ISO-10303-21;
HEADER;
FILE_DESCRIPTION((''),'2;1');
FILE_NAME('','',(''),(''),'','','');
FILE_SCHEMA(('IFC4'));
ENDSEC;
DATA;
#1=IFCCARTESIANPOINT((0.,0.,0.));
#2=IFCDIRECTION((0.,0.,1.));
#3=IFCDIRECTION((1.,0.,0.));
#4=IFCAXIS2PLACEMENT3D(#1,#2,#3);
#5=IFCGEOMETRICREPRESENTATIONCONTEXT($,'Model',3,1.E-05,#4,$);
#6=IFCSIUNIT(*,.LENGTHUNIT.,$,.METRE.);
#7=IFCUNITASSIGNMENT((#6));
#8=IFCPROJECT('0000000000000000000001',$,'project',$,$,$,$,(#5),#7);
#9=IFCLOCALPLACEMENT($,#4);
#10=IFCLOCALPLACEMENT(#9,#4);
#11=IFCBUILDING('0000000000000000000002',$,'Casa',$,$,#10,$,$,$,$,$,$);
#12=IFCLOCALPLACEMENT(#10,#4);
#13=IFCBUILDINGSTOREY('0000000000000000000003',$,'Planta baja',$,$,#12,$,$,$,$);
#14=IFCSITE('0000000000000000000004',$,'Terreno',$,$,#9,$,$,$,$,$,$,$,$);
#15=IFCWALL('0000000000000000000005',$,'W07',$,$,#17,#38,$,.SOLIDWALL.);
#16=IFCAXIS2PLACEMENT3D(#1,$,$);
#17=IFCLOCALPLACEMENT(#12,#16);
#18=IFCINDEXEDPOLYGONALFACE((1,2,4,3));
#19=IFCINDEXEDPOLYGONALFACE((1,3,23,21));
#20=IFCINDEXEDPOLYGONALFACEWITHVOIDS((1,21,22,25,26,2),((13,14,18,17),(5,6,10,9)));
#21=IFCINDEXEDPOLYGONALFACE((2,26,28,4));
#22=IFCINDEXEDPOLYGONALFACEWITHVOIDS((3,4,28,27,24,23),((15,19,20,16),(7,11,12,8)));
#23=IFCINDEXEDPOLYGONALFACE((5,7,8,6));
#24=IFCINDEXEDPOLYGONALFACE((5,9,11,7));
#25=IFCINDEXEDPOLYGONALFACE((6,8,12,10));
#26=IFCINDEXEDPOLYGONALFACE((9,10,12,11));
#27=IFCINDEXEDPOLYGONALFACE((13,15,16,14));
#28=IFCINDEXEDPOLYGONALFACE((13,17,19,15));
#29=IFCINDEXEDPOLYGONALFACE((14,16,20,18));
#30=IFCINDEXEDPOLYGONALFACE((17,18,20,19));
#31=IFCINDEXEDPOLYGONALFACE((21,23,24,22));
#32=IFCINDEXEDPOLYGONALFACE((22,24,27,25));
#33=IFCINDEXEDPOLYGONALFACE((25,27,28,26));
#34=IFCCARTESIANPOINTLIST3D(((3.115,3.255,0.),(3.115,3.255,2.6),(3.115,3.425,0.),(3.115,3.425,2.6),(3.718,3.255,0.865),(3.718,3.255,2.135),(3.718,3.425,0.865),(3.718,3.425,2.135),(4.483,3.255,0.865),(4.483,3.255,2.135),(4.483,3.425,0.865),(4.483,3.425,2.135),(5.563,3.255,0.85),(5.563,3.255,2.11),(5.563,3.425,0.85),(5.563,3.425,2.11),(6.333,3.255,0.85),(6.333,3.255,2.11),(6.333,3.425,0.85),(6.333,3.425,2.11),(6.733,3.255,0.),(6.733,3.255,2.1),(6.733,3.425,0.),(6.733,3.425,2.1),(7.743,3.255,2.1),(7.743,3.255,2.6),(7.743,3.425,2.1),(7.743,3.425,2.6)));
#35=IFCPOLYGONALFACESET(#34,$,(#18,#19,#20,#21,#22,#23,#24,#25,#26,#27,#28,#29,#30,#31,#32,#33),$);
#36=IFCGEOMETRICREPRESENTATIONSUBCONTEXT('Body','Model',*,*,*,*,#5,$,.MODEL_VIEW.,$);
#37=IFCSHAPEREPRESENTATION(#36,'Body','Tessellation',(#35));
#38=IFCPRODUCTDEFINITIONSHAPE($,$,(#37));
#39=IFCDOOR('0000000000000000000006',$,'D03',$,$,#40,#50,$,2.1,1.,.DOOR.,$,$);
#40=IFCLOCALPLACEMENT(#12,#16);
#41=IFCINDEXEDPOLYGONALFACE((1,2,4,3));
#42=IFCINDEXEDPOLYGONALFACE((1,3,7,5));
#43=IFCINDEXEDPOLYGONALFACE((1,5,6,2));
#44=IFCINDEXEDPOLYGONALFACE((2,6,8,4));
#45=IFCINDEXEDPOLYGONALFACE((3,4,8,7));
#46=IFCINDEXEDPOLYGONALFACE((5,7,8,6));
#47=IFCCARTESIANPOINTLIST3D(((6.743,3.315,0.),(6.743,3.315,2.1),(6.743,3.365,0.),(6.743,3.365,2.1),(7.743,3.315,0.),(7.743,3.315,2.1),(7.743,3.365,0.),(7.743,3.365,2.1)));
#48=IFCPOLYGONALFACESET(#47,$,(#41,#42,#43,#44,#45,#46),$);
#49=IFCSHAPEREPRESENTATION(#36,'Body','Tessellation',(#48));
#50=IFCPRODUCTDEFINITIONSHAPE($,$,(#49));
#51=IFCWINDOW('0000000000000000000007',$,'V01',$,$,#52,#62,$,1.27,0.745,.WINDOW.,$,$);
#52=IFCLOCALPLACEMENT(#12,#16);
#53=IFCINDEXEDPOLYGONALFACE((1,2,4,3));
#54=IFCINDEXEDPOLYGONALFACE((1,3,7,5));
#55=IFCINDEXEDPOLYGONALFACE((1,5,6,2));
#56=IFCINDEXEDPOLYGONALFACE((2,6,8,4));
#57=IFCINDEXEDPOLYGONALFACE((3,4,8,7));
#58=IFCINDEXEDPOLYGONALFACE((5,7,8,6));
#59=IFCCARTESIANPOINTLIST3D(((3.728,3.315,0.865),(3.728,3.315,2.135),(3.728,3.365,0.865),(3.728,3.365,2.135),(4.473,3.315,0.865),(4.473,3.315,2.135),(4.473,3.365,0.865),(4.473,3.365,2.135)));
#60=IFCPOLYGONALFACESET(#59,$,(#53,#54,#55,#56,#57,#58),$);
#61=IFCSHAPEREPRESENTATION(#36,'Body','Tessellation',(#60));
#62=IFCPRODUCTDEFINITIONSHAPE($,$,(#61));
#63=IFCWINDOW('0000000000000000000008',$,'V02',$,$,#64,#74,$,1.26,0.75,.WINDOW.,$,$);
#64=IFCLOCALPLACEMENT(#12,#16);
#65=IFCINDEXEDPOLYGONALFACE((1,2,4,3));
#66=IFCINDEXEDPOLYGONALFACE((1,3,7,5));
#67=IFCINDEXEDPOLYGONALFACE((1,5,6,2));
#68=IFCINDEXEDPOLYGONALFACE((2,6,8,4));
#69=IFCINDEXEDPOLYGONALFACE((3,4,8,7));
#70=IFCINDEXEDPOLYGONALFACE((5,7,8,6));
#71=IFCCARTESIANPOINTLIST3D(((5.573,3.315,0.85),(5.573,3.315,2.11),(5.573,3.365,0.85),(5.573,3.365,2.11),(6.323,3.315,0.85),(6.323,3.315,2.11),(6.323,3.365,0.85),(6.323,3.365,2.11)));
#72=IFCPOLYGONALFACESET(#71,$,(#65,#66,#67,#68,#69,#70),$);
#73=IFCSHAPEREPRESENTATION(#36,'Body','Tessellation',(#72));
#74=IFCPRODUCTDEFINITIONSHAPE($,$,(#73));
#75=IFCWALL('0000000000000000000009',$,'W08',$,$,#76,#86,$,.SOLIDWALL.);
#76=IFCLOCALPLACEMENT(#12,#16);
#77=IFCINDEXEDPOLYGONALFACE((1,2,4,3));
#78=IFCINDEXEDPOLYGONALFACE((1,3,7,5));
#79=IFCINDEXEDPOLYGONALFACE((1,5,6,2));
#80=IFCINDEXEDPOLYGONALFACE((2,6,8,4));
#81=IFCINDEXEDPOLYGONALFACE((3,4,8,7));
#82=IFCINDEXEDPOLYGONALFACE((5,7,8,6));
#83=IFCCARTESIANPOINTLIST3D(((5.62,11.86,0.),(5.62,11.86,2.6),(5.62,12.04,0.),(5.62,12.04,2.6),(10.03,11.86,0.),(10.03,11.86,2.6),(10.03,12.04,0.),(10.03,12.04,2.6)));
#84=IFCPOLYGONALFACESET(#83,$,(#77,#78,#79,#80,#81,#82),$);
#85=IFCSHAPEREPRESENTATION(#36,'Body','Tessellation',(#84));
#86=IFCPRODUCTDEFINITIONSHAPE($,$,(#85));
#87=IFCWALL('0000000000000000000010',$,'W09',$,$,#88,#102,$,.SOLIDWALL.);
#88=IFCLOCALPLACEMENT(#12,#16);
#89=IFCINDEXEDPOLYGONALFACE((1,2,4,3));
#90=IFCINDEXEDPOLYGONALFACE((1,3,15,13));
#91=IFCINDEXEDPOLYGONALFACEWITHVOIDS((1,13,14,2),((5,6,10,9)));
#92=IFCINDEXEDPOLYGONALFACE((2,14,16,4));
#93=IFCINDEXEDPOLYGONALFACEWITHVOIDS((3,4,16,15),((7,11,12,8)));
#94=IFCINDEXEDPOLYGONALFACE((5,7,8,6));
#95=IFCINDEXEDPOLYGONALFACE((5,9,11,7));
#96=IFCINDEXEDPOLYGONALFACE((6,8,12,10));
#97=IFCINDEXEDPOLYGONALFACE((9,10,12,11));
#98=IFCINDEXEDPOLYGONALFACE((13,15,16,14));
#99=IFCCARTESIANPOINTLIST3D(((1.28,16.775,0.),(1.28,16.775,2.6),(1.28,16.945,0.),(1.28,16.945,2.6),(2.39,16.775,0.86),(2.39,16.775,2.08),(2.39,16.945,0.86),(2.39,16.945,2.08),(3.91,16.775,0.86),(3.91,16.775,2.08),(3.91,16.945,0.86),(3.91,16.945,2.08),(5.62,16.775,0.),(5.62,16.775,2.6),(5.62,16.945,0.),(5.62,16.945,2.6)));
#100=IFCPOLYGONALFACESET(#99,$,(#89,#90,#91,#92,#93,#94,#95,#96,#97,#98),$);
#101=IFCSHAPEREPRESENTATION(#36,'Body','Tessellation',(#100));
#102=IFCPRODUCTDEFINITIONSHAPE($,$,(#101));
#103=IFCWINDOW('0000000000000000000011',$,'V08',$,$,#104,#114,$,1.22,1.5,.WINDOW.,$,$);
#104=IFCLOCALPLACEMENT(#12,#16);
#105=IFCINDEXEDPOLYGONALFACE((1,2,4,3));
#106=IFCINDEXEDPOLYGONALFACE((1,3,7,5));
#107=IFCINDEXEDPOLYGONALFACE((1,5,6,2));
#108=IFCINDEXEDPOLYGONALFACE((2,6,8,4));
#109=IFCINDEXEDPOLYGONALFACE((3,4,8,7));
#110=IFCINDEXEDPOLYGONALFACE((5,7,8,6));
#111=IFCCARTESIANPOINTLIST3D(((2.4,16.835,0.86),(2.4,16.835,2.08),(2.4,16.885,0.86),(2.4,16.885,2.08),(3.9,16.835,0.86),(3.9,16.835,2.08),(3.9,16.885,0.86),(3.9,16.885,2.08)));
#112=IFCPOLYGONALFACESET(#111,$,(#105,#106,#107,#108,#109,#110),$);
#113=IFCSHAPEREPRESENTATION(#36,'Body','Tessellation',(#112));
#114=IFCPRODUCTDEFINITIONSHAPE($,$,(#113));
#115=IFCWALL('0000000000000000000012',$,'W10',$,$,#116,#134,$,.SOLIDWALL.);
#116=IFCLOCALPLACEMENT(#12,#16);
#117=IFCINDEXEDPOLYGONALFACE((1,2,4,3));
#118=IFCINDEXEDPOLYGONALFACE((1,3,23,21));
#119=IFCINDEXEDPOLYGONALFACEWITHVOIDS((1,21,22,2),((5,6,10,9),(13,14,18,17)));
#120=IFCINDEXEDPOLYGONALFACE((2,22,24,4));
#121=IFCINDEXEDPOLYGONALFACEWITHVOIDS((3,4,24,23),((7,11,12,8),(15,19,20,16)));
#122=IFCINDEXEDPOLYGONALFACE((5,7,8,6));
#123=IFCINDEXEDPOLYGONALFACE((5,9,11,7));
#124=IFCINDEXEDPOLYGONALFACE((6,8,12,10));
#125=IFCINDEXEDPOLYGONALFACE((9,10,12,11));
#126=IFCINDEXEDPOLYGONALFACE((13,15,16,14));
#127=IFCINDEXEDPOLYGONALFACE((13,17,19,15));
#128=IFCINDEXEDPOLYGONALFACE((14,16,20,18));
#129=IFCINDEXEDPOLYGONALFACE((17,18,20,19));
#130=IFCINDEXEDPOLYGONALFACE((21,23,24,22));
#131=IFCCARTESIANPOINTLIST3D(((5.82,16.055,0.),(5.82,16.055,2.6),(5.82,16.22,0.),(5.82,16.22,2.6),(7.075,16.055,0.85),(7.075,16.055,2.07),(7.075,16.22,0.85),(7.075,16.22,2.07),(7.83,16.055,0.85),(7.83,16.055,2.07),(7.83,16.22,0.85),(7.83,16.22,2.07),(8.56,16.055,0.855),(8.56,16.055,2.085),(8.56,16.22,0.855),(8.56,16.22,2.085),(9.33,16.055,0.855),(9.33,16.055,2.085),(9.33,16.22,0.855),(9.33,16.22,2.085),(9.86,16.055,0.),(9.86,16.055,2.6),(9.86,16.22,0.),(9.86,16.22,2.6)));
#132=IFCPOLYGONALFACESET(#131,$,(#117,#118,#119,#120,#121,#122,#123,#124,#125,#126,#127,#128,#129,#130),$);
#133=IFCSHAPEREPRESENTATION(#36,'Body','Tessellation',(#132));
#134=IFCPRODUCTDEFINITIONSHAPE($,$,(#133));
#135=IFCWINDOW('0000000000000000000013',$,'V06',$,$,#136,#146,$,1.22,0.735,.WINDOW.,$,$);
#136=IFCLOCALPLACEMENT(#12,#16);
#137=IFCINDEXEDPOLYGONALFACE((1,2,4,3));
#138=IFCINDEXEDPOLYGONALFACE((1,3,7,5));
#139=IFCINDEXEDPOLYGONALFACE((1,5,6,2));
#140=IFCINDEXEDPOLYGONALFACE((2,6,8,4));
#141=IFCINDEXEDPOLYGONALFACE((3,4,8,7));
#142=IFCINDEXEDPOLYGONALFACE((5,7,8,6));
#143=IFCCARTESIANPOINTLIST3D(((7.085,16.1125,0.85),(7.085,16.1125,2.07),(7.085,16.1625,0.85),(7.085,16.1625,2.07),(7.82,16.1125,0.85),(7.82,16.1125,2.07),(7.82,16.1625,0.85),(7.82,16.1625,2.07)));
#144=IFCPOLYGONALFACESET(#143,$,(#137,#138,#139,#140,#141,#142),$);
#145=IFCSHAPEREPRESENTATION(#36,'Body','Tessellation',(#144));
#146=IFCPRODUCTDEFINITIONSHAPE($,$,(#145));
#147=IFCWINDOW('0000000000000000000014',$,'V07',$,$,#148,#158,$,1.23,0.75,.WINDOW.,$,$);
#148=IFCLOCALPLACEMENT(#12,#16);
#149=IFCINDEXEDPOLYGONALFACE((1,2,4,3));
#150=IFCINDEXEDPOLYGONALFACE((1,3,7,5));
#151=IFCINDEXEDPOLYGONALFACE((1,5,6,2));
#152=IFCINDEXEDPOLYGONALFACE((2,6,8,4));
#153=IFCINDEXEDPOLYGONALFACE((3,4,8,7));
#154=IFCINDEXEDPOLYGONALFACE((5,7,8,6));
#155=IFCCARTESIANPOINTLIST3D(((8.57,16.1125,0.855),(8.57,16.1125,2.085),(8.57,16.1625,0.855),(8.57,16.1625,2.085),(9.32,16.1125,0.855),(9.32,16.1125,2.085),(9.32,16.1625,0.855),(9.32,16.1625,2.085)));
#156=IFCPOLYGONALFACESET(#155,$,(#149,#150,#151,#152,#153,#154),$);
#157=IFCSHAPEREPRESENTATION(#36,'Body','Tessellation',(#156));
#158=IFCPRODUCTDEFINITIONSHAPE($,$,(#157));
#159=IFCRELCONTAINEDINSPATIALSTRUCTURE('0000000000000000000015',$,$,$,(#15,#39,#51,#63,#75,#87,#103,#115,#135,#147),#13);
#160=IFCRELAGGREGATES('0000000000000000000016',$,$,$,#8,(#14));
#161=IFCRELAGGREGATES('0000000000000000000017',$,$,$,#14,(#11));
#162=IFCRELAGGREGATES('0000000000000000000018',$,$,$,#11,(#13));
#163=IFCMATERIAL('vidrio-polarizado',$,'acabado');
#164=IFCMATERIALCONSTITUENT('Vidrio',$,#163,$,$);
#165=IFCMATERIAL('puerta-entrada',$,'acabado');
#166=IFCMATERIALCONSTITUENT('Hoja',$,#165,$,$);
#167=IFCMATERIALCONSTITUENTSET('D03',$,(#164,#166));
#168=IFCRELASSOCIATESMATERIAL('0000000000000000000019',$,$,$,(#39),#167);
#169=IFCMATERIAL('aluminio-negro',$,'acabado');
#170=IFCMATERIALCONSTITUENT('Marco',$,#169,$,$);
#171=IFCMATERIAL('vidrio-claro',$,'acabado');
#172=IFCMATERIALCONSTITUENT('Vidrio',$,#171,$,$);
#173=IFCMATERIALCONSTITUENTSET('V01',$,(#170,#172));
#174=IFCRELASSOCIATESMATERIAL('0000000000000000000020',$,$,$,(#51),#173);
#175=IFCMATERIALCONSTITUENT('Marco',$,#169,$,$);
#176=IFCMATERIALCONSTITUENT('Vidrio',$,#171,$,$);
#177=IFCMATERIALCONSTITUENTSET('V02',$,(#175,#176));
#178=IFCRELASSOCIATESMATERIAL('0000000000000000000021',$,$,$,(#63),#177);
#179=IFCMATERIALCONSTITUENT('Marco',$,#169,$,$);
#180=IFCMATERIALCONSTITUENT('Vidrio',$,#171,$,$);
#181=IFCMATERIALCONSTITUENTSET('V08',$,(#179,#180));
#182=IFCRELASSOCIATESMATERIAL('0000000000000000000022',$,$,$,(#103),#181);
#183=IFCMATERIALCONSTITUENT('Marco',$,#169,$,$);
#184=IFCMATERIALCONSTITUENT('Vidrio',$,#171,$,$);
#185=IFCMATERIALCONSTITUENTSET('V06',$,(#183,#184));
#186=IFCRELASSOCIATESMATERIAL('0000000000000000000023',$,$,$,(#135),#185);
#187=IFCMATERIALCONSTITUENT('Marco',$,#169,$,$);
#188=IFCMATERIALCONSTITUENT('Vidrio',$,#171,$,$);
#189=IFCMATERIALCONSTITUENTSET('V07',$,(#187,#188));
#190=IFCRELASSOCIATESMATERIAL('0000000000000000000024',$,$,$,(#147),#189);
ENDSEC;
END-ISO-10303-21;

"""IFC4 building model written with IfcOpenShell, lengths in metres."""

from ifc_helpers import new_model, si_unit, frame, origin_with_axes, place, context, subcontext, project, spatial, line, indexed_curve, outline, extrude, material, constituent, constituent_set, element, fill, save


model = new_model("IFC4")

# Units and contexts
model_context = context("Model", 3, precision=1e-05, world=origin_with_axes())
body_context = subcontext(model_context, "Body", "Model", "MODEL_VIEW")
ifc_project = project(units=[si_unit("LENGTHUNIT", "METRE")], contexts=[model_context])

# Site, building, storey
site_placement = place(None, origin_with_axes())
site = spatial("IfcSite", under=ifc_project, at=site_placement, Name="Terreno")
building_placement = place(site_placement, origin_with_axes())
building = spatial("IfcBuilding", under=site, at=building_placement, Name="Casa")
storey_placement = place(building_placement, origin_with_axes())
storey = spatial("IfcBuildingStorey", under=building, at=storey_placement, Name="Planta baja")

# Wall, openings, door, windows
wall_1_placement = place(storey_placement, origin_with_axes())
wall_1 = element("IfcWall", 1, at=wall_1_placement, inside=storey, Name="W07", PredefinedType="SOLIDWALL", context=body_context, shape_type="SweptSolid", body=[
    extrude(outline(indexed_curve([(3.115, 3.425), (7.743, 3.425), (7.743, 3.255), (3.115, 3.255)], segments=[line(1, 2, 3, 4, 1)])), origin_with_axes(), (0.0, 0.0, 1.0), 2.6),
])
opening_1_placement = place(wall_1_placement, origin_with_axes())
opening_1 = element("IfcOpeningElement", 2, at=opening_1_placement, cuts=wall_1, PredefinedType="OPENING", context=body_context, shape_type="SweptSolid", body=[
    extrude(outline(indexed_curve([(6.733, 3.245), (7.753, 3.245), (7.753, 3.435), (6.733, 3.435)], segments=[line(1, 2, 3, 4, 1)])), origin_with_axes(), (0.0, 0.0, 1.0), 2.1),
])
opening_2_placement = place(wall_1_placement, origin_with_axes())
opening_2 = element("IfcOpeningElement", 3, at=opening_2_placement, cuts=wall_1, PredefinedType="OPENING", context=body_context, shape_type="SweptSolid", body=[
    extrude(outline(indexed_curve([(3.718, 3.245), (4.483, 3.245), (4.483, 3.435), (3.718, 3.435)], segments=[line(1, 2, 3, 4, 1)])), frame((0.0, 0.0, 0.865), z_axis=(0.0, 0.0, 1.0), x_axis=(1.0, 0.0, 0.0)), (0.0, 0.0, 1.0), 1.27),
])
opening_3_placement = place(wall_1_placement, origin_with_axes())
opening_3 = element("IfcOpeningElement", 4, at=opening_3_placement, cuts=wall_1, PredefinedType="OPENING", context=body_context, shape_type="SweptSolid", body=[
    extrude(outline(indexed_curve([(5.563, 3.245), (6.333, 3.245), (6.333, 3.435), (5.563, 3.435)], segments=[line(1, 2, 3, 4, 1)])), frame((0.0, 0.0, 0.85), z_axis=(0.0, 0.0, 1.0), x_axis=(1.0, 0.0, 0.0)), (0.0, 0.0, 1.0), 1.26),
])
ifc_material_1 = material(Name="vidrio-polarizado", Category="acabado")
ifc_constituent_1 = constituent(ifc_material_1, Name="Vidrio")
ifc_material_2 = material(Name="puerta-entrada", Category="acabado")
ifc_constituent_2 = constituent(ifc_material_2, Name="Hoja")
ifc_constituent_set_1 = constituent_set(constituents=[ifc_constituent_1, ifc_constituent_2], Name="D03")
door_1_placement = place(opening_1_placement, origin_with_axes())
door_1 = element("IfcDoor", 5, at=door_1_placement, inside=storey, material=ifc_constituent_set_1, Name="D03", OverallHeight=2.1, OverallWidth=1.0, PredefinedType="DOOR", context=body_context, shape_type="SweptSolid", body=[
    extrude(outline(indexed_curve([(6.743, 3.315), (7.743, 3.315), (7.743, 3.365), (6.743, 3.365)], segments=[line(1, 2, 3, 4, 1)])), origin_with_axes(), (0.0, 0.0, 1.0), 2.1),
])
fill(opening_1, door_1)
ifc_material_3 = material(Name="aluminio-negro", Category="acabado")
ifc_constituent_3 = constituent(ifc_material_3, Name="Marco")
ifc_material_4 = material(Name="vidrio-claro", Category="acabado")
ifc_constituent_4 = constituent(ifc_material_4, Name="Vidrio")
ifc_constituent_set_2 = constituent_set(constituents=[ifc_constituent_3, ifc_constituent_4], Name="V01")
window_1_placement = place(opening_2_placement, origin_with_axes())
window_1 = element("IfcWindow", 6, at=window_1_placement, inside=storey, material=ifc_constituent_set_2, Name="V01", OverallHeight=1.27, OverallWidth=0.745, PredefinedType="WINDOW", context=body_context, shape_type="SweptSolid", body=[
    extrude(outline(indexed_curve([(3.728, 3.315), (4.473, 3.315), (4.473, 3.365), (3.728, 3.365)], segments=[line(1, 2, 3, 4, 1)])), frame((0.0, 0.0, 0.865), z_axis=(0.0, 0.0, 1.0), x_axis=(1.0, 0.0, 0.0)), (0.0, 0.0, 1.0), 1.27),
])
fill(opening_2, window_1)
ifc_constituent_5 = constituent(ifc_material_3, Name="Marco")
ifc_constituent_6 = constituent(ifc_material_4, Name="Vidrio")
ifc_constituent_set_3 = constituent_set(constituents=[ifc_constituent_5, ifc_constituent_6], Name="V02")
window_2_placement = place(opening_3_placement, origin_with_axes())
window_2 = element("IfcWindow", 7, at=window_2_placement, inside=storey, material=ifc_constituent_set_3, Name="V02", OverallHeight=1.26, OverallWidth=0.75, PredefinedType="WINDOW", context=body_context, shape_type="SweptSolid", body=[
    extrude(outline(indexed_curve([(5.573, 3.315), (6.323, 3.315), (6.323, 3.365), (5.573, 3.365)], segments=[line(1, 2, 3, 4, 1)])), frame((0.0, 0.0, 0.85), z_axis=(0.0, 0.0, 1.0), x_axis=(1.0, 0.0, 0.0)), (0.0, 0.0, 1.0), 1.26),
])
fill(opening_3, window_2)

# Wall
wall_2_placement = place(storey_placement, origin_with_axes())
element("IfcWall", 8, at=wall_2_placement, inside=storey, Name="W08", PredefinedType="SOLIDWALL", context=body_context, shape_type="SweptSolid", body=[
    extrude(outline(indexed_curve([(5.62, 11.86), (5.62, 12.04), (10.03, 12.04), (10.03, 11.86)], segments=[line(1, 2, 3, 4, 1)])), origin_with_axes(), (0.0, 0.0, 1.0), 2.6),
])

# Wall, opening, window
wall_3_placement = place(storey_placement, origin_with_axes())
wall_3 = element("IfcWall", 9, at=wall_3_placement, inside=storey, Name="W09", PredefinedType="SOLIDWALL", context=body_context, shape_type="SweptSolid", body=[
    extrude(outline(indexed_curve([(1.28, 16.775), (1.28, 16.945), (5.62, 16.945), (5.62, 16.775)], segments=[line(1, 2, 3, 4, 1)])), origin_with_axes(), (0.0, 0.0, 1.0), 2.6),
])
opening_4_placement = place(wall_3_placement, origin_with_axes())
opening_4 = element("IfcOpeningElement", 10, at=opening_4_placement, cuts=wall_3, PredefinedType="OPENING", context=body_context, shape_type="SweptSolid", body=[
    extrude(outline(indexed_curve([(2.39, 16.765), (3.91, 16.765), (3.91, 16.955), (2.39, 16.955)], segments=[line(1, 2, 3, 4, 1)])), frame((0.0, 0.0, 0.86), z_axis=(0.0, 0.0, 1.0), x_axis=(1.0, 0.0, 0.0)), (0.0, 0.0, 1.0), 1.22),
])
ifc_constituent_7 = constituent(ifc_material_3, Name="Marco")
ifc_constituent_8 = constituent(ifc_material_4, Name="Vidrio")
ifc_constituent_set_4 = constituent_set(constituents=[ifc_constituent_7, ifc_constituent_8], Name="V08")
window_3_placement = place(opening_4_placement, origin_with_axes())
window_3 = element("IfcWindow", 11, at=window_3_placement, inside=storey, material=ifc_constituent_set_4, Name="V08", OverallHeight=1.22, OverallWidth=1.5, PredefinedType="WINDOW", context=body_context, shape_type="SweptSolid", body=[
    extrude(outline(indexed_curve([(2.4, 16.835), (3.9, 16.835), (3.9, 16.885), (2.4, 16.885)], segments=[line(1, 2, 3, 4, 1)])), frame((0.0, 0.0, 0.86), z_axis=(0.0, 0.0, 1.0), x_axis=(1.0, 0.0, 0.0)), (0.0, 0.0, 1.0), 1.22),
])
fill(opening_4, window_3)

# Wall, openings, windows
wall_4_placement = place(storey_placement, origin_with_axes())
wall_4 = element("IfcWall", 12, at=wall_4_placement, inside=storey, Name="W10", PredefinedType="SOLIDWALL", context=body_context, shape_type="SweptSolid", body=[
    extrude(outline(indexed_curve([(5.82, 16.055), (5.82, 16.22), (9.86, 16.22), (9.86, 16.055)], segments=[line(1, 2, 3, 4, 1)])), origin_with_axes(), (0.0, 0.0, 1.0), 2.6),
])
opening_5_placement = place(wall_4_placement, origin_with_axes())
opening_5 = element("IfcOpeningElement", 13, at=opening_5_placement, cuts=wall_4, PredefinedType="OPENING", context=body_context, shape_type="SweptSolid", body=[
    extrude(outline(indexed_curve([(7.075, 16.045), (7.83, 16.045), (7.83, 16.23), (7.075, 16.23)], segments=[line(1, 2, 3, 4, 1)])), frame((0.0, 0.0, 0.85), z_axis=(0.0, 0.0, 1.0), x_axis=(1.0, 0.0, 0.0)), (0.0, 0.0, 1.0), 1.22),
])
opening_6_placement = place(wall_4_placement, origin_with_axes())
opening_6 = element("IfcOpeningElement", 14, at=opening_6_placement, cuts=wall_4, PredefinedType="OPENING", context=body_context, shape_type="SweptSolid", body=[
    extrude(outline(indexed_curve([(8.56, 16.045), (9.33, 16.045), (9.33, 16.23), (8.56, 16.23)], segments=[line(1, 2, 3, 4, 1)])), frame((0.0, 0.0, 0.855), z_axis=(0.0, 0.0, 1.0), x_axis=(1.0, 0.0, 0.0)), (0.0, 0.0, 1.0), 1.23),
])
ifc_constituent_9 = constituent(ifc_material_3, Name="Marco")
ifc_constituent_10 = constituent(ifc_material_4, Name="Vidrio")
ifc_constituent_set_5 = constituent_set(constituents=[ifc_constituent_9, ifc_constituent_10], Name="V06")
window_4_placement = place(opening_5_placement, origin_with_axes())
window_4 = element("IfcWindow", 15, at=window_4_placement, inside=storey, material=ifc_constituent_set_5, Name="V06", OverallHeight=1.22, OverallWidth=0.735, PredefinedType="WINDOW", context=body_context, shape_type="SweptSolid", body=[
    extrude(outline(indexed_curve([(7.085, 16.1125), (7.82, 16.1125), (7.82, 16.1625), (7.085, 16.1625)], segments=[line(1, 2, 3, 4, 1)])), frame((0.0, 0.0, 0.85), z_axis=(0.0, 0.0, 1.0), x_axis=(1.0, 0.0, 0.0)), (0.0, 0.0, 1.0), 1.22),
])
fill(opening_5, window_4)
ifc_constituent_11 = constituent(ifc_material_3, Name="Marco")
ifc_constituent_12 = constituent(ifc_material_4, Name="Vidrio")
ifc_constituent_set_6 = constituent_set(constituents=[ifc_constituent_11, ifc_constituent_12], Name="V07")
window_5_placement = place(opening_6_placement, origin_with_axes())
window_5 = element("IfcWindow", 16, at=window_5_placement, inside=storey, material=ifc_constituent_set_6, Name="V07", OverallHeight=1.23, OverallWidth=0.75, PredefinedType="WINDOW", context=body_context, shape_type="SweptSolid", body=[
    extrude(outline(indexed_curve([(8.57, 16.1125), (9.32, 16.1125), (9.32, 16.1625), (8.57, 16.1625)], segments=[line(1, 2, 3, 4, 1)])), frame((0.0, 0.0, 0.855), z_axis=(0.0, 0.0, 1.0), x_axis=(1.0, 0.0, 0.0)), (0.0, 0.0, 1.0), 1.23),
])
fill(opening_6, window_5)

save(model, "model.ifc")
